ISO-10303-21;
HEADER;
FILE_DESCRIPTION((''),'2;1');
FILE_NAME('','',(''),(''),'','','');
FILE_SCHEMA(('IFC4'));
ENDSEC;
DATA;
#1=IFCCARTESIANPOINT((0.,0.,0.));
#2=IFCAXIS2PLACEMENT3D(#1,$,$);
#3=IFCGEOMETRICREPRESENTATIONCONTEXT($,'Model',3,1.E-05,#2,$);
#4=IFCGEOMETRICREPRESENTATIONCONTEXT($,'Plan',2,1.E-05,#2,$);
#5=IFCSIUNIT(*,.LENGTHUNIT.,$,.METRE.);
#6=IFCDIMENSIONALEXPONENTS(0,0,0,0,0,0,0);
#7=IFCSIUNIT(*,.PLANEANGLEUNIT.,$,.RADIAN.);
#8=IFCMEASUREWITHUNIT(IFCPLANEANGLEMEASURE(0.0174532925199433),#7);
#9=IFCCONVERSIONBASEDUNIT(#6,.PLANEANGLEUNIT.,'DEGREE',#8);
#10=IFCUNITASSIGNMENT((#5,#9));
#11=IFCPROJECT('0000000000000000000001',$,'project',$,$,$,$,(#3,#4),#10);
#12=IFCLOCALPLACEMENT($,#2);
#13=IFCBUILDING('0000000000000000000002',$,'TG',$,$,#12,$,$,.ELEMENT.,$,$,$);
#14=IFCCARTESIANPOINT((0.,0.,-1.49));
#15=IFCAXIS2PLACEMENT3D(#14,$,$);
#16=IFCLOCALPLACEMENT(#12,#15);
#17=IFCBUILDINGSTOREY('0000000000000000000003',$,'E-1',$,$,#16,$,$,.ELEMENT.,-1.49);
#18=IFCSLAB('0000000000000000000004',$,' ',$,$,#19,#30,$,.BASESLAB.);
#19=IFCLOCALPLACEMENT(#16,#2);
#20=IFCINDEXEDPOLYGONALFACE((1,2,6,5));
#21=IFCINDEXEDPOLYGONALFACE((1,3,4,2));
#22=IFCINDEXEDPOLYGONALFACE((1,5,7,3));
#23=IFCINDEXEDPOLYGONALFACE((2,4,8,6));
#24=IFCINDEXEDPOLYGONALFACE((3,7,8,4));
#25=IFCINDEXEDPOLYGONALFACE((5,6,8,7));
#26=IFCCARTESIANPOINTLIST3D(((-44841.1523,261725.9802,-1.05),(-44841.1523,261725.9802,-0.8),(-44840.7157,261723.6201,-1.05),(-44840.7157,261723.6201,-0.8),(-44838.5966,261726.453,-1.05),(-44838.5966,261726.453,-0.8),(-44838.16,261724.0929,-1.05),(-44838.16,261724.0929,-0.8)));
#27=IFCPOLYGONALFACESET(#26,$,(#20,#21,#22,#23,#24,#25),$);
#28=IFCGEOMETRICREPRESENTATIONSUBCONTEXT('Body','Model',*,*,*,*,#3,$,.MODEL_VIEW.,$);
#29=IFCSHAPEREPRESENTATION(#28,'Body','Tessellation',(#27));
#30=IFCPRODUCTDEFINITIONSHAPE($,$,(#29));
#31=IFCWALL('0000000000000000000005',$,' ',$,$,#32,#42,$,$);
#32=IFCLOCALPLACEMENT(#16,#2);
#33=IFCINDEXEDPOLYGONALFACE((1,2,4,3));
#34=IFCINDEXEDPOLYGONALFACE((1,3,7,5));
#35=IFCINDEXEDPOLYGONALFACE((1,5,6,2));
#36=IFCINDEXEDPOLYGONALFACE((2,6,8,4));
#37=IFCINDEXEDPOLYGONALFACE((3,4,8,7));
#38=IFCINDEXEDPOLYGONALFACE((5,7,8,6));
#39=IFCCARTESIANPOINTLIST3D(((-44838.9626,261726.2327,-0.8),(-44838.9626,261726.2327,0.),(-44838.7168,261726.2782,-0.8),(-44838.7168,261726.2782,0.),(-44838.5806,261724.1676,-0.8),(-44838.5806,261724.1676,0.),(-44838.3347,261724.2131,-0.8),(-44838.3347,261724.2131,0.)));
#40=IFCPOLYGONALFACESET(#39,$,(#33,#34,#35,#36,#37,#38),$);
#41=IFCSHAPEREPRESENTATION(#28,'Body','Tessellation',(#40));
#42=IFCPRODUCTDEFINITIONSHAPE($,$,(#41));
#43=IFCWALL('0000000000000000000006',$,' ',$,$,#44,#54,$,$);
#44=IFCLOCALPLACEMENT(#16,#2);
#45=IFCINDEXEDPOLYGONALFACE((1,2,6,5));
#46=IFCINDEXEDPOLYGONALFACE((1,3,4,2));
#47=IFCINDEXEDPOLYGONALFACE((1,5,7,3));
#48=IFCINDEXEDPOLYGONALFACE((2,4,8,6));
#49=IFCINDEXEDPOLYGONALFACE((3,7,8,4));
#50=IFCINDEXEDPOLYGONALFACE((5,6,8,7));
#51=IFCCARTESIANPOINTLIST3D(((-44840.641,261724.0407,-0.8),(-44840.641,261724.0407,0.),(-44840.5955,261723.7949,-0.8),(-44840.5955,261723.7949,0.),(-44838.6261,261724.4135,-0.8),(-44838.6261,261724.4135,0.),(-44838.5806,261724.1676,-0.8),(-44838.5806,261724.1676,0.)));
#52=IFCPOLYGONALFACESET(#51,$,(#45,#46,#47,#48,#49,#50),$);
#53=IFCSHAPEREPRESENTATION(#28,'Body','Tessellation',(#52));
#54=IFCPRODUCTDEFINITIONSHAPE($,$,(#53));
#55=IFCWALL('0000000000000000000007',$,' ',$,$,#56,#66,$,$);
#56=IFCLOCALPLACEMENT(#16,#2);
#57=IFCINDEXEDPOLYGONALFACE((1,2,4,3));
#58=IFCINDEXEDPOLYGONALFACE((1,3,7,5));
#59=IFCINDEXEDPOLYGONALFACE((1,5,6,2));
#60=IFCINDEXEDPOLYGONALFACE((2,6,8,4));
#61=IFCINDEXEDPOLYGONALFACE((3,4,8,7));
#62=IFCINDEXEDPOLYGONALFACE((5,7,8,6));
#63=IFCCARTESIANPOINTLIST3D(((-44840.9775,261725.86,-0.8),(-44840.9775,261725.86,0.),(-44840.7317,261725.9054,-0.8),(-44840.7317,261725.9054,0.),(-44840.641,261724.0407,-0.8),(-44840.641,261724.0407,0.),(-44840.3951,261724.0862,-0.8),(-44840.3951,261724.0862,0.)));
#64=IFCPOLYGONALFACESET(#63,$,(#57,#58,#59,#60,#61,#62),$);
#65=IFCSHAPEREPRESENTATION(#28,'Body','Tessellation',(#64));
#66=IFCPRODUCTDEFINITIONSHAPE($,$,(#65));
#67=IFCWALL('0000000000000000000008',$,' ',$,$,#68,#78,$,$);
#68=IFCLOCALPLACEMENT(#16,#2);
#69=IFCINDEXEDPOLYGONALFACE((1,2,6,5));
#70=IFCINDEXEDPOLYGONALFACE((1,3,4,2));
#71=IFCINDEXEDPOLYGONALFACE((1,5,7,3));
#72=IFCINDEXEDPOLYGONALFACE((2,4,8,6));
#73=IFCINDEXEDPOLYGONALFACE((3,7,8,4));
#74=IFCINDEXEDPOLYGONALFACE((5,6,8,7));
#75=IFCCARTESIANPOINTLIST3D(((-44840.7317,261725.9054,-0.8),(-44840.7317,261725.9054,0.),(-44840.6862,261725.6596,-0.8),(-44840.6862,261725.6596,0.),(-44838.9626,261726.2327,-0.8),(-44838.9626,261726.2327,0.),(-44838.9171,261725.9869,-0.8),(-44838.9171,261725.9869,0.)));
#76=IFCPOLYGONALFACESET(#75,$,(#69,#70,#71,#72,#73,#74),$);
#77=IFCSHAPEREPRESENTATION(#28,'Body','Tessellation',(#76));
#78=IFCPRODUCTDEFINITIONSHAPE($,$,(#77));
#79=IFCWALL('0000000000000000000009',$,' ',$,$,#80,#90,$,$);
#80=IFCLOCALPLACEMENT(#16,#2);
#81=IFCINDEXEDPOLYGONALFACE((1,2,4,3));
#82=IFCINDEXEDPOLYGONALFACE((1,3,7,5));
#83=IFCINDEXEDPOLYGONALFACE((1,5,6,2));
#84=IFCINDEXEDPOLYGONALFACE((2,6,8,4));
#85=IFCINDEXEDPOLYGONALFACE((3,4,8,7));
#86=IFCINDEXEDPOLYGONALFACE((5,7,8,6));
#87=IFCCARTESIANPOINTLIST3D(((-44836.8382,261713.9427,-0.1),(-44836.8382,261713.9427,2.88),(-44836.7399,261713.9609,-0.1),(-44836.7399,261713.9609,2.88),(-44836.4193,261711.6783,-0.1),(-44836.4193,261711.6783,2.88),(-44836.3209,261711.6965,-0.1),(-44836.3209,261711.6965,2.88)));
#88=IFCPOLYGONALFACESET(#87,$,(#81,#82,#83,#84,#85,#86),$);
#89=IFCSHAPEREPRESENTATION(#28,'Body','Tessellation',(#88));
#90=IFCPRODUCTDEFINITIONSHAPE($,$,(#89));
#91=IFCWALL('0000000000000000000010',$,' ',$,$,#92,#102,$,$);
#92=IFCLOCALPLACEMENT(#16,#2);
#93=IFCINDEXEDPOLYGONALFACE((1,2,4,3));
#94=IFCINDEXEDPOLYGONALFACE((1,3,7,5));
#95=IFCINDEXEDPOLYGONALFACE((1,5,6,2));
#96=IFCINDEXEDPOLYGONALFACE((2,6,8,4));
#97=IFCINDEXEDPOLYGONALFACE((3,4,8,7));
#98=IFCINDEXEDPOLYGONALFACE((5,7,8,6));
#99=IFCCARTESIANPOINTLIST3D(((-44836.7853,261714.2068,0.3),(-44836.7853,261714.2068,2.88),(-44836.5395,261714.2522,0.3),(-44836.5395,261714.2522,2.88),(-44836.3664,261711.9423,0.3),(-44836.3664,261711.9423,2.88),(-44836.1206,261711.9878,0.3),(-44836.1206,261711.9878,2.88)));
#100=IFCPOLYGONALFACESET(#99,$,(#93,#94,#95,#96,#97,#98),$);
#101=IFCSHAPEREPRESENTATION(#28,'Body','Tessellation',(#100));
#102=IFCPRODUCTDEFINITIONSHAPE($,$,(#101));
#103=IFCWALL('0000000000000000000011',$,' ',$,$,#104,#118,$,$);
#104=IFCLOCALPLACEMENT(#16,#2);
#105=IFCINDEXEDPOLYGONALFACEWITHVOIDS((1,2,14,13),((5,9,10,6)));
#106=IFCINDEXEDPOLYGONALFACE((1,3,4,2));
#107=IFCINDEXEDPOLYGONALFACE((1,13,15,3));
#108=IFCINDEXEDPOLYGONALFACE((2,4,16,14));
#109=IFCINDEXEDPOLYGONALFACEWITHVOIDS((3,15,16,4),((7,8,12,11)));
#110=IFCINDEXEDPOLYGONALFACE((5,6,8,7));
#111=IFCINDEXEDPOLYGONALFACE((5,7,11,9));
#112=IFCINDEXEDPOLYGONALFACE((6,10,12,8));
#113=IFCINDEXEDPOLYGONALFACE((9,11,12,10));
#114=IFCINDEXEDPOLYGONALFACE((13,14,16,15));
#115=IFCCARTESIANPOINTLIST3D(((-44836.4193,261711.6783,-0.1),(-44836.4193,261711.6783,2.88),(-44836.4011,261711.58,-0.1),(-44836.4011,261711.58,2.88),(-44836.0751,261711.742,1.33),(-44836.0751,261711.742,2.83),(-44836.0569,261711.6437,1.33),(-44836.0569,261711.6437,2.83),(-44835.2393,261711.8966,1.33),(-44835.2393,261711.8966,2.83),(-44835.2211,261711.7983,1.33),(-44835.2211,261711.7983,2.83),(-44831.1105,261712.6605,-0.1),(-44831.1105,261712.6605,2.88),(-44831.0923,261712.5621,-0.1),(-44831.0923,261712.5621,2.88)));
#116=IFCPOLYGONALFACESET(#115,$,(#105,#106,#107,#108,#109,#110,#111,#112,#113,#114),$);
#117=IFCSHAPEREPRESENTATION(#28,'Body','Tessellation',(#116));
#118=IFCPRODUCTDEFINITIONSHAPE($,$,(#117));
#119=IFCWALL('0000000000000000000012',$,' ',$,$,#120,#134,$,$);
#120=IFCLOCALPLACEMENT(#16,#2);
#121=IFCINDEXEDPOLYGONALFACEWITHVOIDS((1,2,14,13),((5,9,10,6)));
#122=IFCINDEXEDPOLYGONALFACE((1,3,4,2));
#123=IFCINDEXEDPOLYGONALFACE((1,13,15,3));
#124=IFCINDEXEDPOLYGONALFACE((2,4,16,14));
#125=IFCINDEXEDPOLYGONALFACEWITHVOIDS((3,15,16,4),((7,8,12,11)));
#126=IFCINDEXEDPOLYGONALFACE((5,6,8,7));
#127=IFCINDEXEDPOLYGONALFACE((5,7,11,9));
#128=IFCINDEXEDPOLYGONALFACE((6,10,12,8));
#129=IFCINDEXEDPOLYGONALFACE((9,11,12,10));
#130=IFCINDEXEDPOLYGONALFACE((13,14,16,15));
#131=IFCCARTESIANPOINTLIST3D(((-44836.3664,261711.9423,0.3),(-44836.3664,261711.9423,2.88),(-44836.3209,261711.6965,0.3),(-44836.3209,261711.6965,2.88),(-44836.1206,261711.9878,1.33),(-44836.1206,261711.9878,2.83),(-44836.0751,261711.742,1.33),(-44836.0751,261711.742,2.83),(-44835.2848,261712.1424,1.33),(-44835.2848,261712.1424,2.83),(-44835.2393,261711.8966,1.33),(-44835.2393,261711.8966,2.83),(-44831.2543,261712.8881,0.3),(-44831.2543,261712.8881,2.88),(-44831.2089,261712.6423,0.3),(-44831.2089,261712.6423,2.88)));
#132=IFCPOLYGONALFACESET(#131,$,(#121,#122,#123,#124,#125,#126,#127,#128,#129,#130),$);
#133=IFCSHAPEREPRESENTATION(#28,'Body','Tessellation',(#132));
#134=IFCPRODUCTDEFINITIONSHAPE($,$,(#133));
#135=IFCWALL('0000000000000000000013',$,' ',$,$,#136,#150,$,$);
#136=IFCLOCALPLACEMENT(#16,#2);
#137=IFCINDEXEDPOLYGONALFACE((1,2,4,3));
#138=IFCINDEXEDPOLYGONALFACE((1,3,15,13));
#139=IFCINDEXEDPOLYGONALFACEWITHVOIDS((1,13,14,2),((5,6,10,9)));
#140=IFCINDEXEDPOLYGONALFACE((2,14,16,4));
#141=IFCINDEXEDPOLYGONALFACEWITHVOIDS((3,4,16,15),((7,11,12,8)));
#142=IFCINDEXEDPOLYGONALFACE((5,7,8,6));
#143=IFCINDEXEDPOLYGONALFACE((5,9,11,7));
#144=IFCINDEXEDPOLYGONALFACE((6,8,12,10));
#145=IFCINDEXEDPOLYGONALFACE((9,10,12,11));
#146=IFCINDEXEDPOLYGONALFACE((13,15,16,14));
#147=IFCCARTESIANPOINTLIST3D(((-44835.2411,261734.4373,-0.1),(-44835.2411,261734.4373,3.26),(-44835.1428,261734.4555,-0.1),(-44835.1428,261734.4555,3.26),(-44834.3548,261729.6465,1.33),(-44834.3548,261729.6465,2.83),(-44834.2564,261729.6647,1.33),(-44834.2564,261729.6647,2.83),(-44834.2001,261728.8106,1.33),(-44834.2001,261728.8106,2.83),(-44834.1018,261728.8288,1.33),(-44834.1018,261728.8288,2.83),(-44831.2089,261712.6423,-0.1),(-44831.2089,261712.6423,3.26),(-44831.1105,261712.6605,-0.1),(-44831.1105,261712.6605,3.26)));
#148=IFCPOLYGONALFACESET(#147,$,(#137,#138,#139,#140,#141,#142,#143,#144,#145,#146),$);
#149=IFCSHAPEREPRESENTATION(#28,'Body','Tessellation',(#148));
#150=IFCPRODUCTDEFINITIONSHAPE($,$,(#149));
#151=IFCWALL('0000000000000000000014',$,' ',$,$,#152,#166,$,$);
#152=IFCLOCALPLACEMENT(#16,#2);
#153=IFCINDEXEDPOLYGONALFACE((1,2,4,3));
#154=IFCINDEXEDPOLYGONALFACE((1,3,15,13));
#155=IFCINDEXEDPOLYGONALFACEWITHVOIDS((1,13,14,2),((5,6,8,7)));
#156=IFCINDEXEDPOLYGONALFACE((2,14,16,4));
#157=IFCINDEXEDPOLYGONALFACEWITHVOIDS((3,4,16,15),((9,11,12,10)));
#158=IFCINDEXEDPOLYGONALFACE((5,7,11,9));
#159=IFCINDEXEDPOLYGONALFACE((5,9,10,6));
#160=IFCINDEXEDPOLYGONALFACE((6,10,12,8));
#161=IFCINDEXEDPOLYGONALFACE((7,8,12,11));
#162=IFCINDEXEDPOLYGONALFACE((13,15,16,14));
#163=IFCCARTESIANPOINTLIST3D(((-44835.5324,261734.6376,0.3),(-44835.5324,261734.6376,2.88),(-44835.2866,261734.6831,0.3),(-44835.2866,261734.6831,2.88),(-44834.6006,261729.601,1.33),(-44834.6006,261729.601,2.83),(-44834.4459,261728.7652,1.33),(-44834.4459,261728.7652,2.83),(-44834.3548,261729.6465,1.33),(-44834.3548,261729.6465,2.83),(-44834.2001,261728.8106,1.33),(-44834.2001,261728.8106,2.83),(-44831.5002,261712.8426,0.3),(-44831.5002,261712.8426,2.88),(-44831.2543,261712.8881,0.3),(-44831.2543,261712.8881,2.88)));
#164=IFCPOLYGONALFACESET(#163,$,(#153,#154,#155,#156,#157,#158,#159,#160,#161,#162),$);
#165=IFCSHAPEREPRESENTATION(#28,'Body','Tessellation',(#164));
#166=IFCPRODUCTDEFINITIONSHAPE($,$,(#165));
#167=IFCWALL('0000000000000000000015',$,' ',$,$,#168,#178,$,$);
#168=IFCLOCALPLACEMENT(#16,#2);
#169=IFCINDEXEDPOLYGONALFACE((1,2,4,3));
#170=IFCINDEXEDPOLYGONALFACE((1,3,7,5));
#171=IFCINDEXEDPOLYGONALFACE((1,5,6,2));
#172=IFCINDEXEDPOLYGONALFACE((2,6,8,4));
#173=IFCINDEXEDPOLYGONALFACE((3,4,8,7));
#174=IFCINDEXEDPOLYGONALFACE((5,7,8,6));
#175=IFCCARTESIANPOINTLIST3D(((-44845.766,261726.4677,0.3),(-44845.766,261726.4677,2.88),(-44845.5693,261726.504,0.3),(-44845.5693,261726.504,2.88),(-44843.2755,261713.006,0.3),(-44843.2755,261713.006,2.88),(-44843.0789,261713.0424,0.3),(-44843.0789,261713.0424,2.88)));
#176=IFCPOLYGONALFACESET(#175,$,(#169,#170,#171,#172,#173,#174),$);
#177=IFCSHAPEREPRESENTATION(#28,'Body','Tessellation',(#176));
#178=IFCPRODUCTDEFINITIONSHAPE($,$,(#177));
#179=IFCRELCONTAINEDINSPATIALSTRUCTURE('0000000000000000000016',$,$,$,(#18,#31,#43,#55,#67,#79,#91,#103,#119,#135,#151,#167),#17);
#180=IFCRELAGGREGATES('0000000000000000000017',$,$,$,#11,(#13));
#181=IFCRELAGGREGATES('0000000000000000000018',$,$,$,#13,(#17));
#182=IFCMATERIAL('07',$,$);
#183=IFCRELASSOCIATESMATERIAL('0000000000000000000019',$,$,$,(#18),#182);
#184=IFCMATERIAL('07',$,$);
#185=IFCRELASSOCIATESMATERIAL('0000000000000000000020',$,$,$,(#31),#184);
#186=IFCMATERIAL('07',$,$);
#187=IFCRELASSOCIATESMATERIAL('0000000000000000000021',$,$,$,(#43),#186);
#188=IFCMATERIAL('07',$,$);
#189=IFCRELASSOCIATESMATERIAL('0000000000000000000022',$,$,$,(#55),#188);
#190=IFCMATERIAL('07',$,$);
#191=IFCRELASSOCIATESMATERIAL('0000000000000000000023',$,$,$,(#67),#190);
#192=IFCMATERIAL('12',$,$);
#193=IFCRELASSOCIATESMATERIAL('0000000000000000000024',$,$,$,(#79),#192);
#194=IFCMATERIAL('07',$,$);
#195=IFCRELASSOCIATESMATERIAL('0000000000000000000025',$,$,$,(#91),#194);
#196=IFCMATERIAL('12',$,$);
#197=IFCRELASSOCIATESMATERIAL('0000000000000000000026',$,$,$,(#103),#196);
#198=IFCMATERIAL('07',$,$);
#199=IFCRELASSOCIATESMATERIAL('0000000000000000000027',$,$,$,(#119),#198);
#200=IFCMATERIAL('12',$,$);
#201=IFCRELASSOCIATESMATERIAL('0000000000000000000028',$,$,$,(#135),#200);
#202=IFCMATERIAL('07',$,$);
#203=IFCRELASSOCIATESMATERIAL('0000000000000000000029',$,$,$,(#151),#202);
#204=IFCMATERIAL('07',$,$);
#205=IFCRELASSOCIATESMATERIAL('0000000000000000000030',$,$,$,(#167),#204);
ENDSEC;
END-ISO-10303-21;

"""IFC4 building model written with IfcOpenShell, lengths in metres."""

from ifc_helpers import new_model, entity, si_unit, converted_unit, frame, frame_2d, origin, origin_with_axes, place, context, subcontext, project, spatial, polyline, rectangle, outline, extrude, material, element, save


model = new_model("IFC4")

# Units and contexts
model_context = context("Model", 3, precision=1e-05, world=origin())
plan_context = context("Plan", 2, precision=1e-05, world=origin())
body_context = subcontext(model_context, "Body", "Model", "MODEL_VIEW")
ifc_project = project(units=[si_unit("LENGTHUNIT", "METRE"), converted_unit("PLANEANGLEUNIT", "DEGREE", entity("IfcPlaneAngleMeasure", 0.0174532925199433), si_unit("PLANEANGLEUNIT", "RADIAN"), dimensions=[0, 0, 0, 0, 0, 0, 0])], contexts=[model_context, plan_context])

# Building, storey
building_placement = place(None, origin())
building = spatial("IfcBuilding", under=ifc_project, at=building_placement, Name="TG", CompositionType="ELEMENT")
storey_placement = place(building_placement, frame((0.0, 0.0, -1.49)))
storey = spatial("IfcBuildingStorey", under=building, at=storey_placement, Name="E-1", CompositionType="ELEMENT", Elevation=-1.49)

# Slab
ifc_material_1 = material(Name="07")
slab_placement = place(storey_placement, frame((-44841.1523, 261723.6201, -1.05)))
element("IfcSlab", 1, at=slab_placement, inside=storey, material=ifc_material_1, Name=" ", PredefinedType="BASESLAB", context=body_context, shape_type="SweptSolid", body=[
    extrude(rectangle(XDim=2.4001, YDim=2.5991, at=frame_2d((1.4962, -0.9436), x_axis=(0.18192, -0.983313))), frame((0.0, 2.3601, 0.0), z_axis=(0.0, 0.0, 1.0), x_axis=(1.0, 0.0, 0.0)), (0.0, 0.0, 1.0), 0.25),
])

# Walls
ifc_material_2 = material(Name="07")
wall_1_placement = place(storey_placement, frame((-44838.9626, 261726.2327, -0.8), z_axis=(0.0, 0.0, 1.0), x_axis=(0.18192, -0.983313, 0.0)))
element("IfcWall", 2, at=wall_1_placement, inside=storey, material=ifc_material_2, Name=" ", context=body_context, shape_type="SweptSolid", body=[
    extrude(rectangle(XDim=2.1001, YDim=0.25, at=frame_2d((1.0501, 0.125), x_axis=(1.0, 0.0))), origin_with_axes(), (0.0, 0.0, 1.0), 0.8),
])
ifc_material_3 = material(Name="07")
wall_2_placement = place(storey_placement, frame((-44838.6261, 261724.4135, -0.8), z_axis=(0.0, 0.0, 1.0), x_axis=(-0.983313, -0.18192, 0.0)))
element("IfcWall", 3, at=wall_2_placement, inside=storey, material=ifc_material_3, Name=" ", context=body_context, shape_type="SweptSolid", body=[
    extrude(rectangle(XDim=2.0491, YDim=0.25, at=frame_2d((1.0245, 0.125), x_axis=(1.0, 0.0))), origin_with_axes(), (0.0, 0.0, 1.0), 0.8),
])
ifc_material_4 = material(Name="07")
wall_3_placement = place(storey_placement, frame((-44840.3951, 261724.0862, -0.8), z_axis=(0.0, 0.0, 1.0), x_axis=(-0.18192, 0.983313, 0.0)))
element("IfcWall", 4, at=wall_3_placement, inside=storey, material=ifc_material_4, Name=" ", context=body_context, shape_type="SweptSolid", body=[
    extrude(rectangle(XDim=1.8501, YDim=0.25, at=frame_2d((0.9251, 0.125), x_axis=(1.0, 0.0))), origin_with_axes(), (0.0, 0.0, 1.0), 0.8),
])
ifc_material_5 = material(Name="07")
wall_4_placement = place(storey_placement, frame((-44840.6862, 261725.6596, -0.8), z_axis=(0.0, 0.0, 1.0), x_axis=(0.983313, 0.18192, 0.0)))
element("IfcWall", 5, at=wall_4_placement, inside=storey, material=ifc_material_5, Name=" ", context=body_context, shape_type="SweptSolid", body=[
    extrude(rectangle(XDim=1.7991, YDim=0.25, at=frame_2d((0.8995, 0.125), x_axis=(1.0, 0.0))), origin_with_axes(), (0.0, 0.0, 1.0), 0.8),
])
ifc_material_6 = material(Name="12")
wall_5_placement = place(storey_placement, frame((-44836.8382, 261713.9427, -0.1), z_axis=(0.0, 0.0, 1.0), x_axis=(0.18192, -0.983313, 0.0)))
element("IfcWall", 6, at=wall_5_placement, inside=storey, material=ifc_material_6, Name=" ", context=body_context, shape_type="SweptSolid", body=[
    extrude(rectangle(XDim=2.3028, YDim=0.1, at=frame_2d((1.1514, 0.05), x_axis=(1.0, 0.0))), origin_with_axes(), (0.0, 0.0, 1.0), 2.98),
])
ifc_material_7 = material(Name="07")
wall_6_placement = place(storey_placement, frame((-44836.7853, 261714.2068, 0.3), z_axis=(0.0, 0.0, 1.0), x_axis=(0.18192, -0.983313, 0.0)))
element("IfcWall", 7, at=wall_6_placement, inside=storey, material=ifc_material_7, Name=" ", context=body_context, shape_type="SweptSolid", body=[
    extrude(rectangle(XDim=2.3028, YDim=0.25, at=frame_2d((1.1514, 0.125), x_axis=(1.0, 0.0))), origin_with_axes(), (0.0, 0.0, 1.0), 2.58),
])

# Walls, openings
ifc_material_8 = material(Name="12")
wall_7_placement = place(storey_placement, frame((-44836.4011, 261711.58, -0.1), z_axis=(0.0, 0.0, 1.0), x_axis=(0.983313, 0.18192, 0.0)))
wall_7 = element("IfcWall", 8, at=wall_7_placement, inside=storey, material=ifc_material_8, Name=" ", context=body_context, shape_type="SweptSolid", body=[
    extrude(rectangle(XDim=5.3988, YDim=0.1, at=frame_2d((2.6994, 0.05), x_axis=(1.0, 0.0))), origin_with_axes(), (0.0, 0.0, 1.0), 2.98),
])
opening_1_placement = place(wall_7_placement, frame((1.2, 0.1, 1.43), z_axis=(0.0, -1.0, 0.0), x_axis=(0.0, 0.0, 1.0)))
element("IfcOpeningElement", 9, at=opening_1_placement, cuts=wall_7, ObjectType="Opening", context=body_context, shape_type="SweptSolid", body=[
    extrude(outline(polyline([(0.0, 0.85), (1.5, 0.85), (1.5, 0.0), (0.0, 0.0), (0.0, 0.85)])), origin_with_axes(), (0.0, 0.0, 1.0), 0.1),
])
ifc_material_9 = material(Name="07")
wall_8_placement = place(storey_placement, frame((-44836.3209, 261711.6965, 0.3), z_axis=(0.0, 0.0, 1.0), x_axis=(0.983313, 0.18192, 0.0)))
wall_8 = element("IfcWall", 10, at=wall_8_placement, inside=storey, material=ifc_material_9, Name=" ", context=body_context, shape_type="SweptSolid", body=[
    extrude(rectangle(XDim=5.1988, YDim=0.25, at=frame_2d((2.5994, 0.125), x_axis=(1.0, 0.0))), origin_with_axes(), (0.0, 0.0, 1.0), 2.58),
])
opening_2_placement = place(wall_8_placement, frame((1.1, 0.25, 1.03), z_axis=(0.0, -1.0, 0.0), x_axis=(0.0, 0.0, 1.0)))
element("IfcOpeningElement", 11, at=opening_2_placement, cuts=wall_8, ObjectType="Opening", context=body_context, shape_type="SweptSolid", body=[
    extrude(outline(polyline([(0.0, 0.85), (1.5, 0.85), (1.5, 0.0), (0.0, 0.0), (0.0, 0.85)])), origin_with_axes(), (0.0, 0.0, 1.0), 0.25),
])
ifc_material_10 = material(Name="12")
wall_9_placement = place(storey_placement, frame((-44831.1105, 261712.6605, -0.1), z_axis=(0.0, 0.0, 1.0), x_axis=(-0.18192, 0.983313, 0.0)))
wall_9 = element("IfcWall", 12, at=wall_9_placement, inside=storey, material=ifc_material_10, Name=" ", context=body_context, shape_type="SweptSolid", body=[
    extrude(rectangle(XDim=22.1649, YDim=0.1, at=frame_2d((11.0824, 0.05), x_axis=(1.0, 0.0))), origin_with_axes(), (0.0, 0.0, 1.0), 3.36),
])
opening_3_placement = place(wall_9_placement, frame((17.2927, 0.1, 1.43), z_axis=(0.0, -1.0, 0.0), x_axis=(0.0, 0.0, 1.0)))
element("IfcOpeningElement", 13, at=opening_3_placement, cuts=wall_9, ObjectType="Opening", context=body_context, shape_type="SweptSolid", body=[
    extrude(outline(polyline([(0.0, 0.85), (1.5, 0.85), (1.5, 0.0), (0.0, 0.0), (0.0, 0.85)])), origin_with_axes(), (0.0, 0.0, 1.0), 0.1),
])
ifc_material_11 = material(Name="07")
wall_10_placement = place(storey_placement, frame((-44831.2543, 261712.8881, 0.3), z_axis=(0.0, 0.0, 1.0), x_axis=(-0.18192, 0.983313, 0.0)))
wall_10 = element("IfcWall", 14, at=wall_10_placement, inside=storey, material=ifc_material_11, Name=" ", context=body_context, shape_type="SweptSolid", body=[
    extrude(rectangle(XDim=22.1649, YDim=0.25, at=frame_2d((11.0824, 0.125), x_axis=(1.0, 0.0))), origin_with_axes(), (0.0, 0.0, 1.0), 2.58),
])
opening_4_placement = place(wall_10_placement, frame((17.0427, 0.25, 1.03), z_axis=(0.0, -1.0, 0.0), x_axis=(0.0, 0.0, 1.0)))
element("IfcOpeningElement", 15, at=opening_4_placement, cuts=wall_10, ObjectType="Opening", context=body_context, shape_type="SweptSolid", body=[
    extrude(outline(polyline([(0.0, 0.85), (1.5, 0.85), (1.5, 0.0), (0.0, 0.0), (0.0, 0.85)])), origin_with_axes(), (0.0, 0.0, 1.0), 0.25),
])

# Wall
ifc_material_12 = material(Name="07")
wall_11_placement = place(storey_placement, frame((-44843.0789, 261713.0424, 0.3), z_axis=(0.0, 0.0, 1.0), x_axis=(-0.18192, 0.983313, 0.0)))
element("IfcWall", 16, at=wall_11_placement, inside=storey, material=ifc_material_12, Name=" ", context=body_context, shape_type="SweptSolid", body=[
    extrude(rectangle(XDim=13.6901, YDim=0.2, at=frame_2d((6.845, 0.1), x_axis=(1.0, 0.0))), origin_with_axes(), (0.0, 0.0, 1.0), 2.58),
])

save(model, "model.ifc")
